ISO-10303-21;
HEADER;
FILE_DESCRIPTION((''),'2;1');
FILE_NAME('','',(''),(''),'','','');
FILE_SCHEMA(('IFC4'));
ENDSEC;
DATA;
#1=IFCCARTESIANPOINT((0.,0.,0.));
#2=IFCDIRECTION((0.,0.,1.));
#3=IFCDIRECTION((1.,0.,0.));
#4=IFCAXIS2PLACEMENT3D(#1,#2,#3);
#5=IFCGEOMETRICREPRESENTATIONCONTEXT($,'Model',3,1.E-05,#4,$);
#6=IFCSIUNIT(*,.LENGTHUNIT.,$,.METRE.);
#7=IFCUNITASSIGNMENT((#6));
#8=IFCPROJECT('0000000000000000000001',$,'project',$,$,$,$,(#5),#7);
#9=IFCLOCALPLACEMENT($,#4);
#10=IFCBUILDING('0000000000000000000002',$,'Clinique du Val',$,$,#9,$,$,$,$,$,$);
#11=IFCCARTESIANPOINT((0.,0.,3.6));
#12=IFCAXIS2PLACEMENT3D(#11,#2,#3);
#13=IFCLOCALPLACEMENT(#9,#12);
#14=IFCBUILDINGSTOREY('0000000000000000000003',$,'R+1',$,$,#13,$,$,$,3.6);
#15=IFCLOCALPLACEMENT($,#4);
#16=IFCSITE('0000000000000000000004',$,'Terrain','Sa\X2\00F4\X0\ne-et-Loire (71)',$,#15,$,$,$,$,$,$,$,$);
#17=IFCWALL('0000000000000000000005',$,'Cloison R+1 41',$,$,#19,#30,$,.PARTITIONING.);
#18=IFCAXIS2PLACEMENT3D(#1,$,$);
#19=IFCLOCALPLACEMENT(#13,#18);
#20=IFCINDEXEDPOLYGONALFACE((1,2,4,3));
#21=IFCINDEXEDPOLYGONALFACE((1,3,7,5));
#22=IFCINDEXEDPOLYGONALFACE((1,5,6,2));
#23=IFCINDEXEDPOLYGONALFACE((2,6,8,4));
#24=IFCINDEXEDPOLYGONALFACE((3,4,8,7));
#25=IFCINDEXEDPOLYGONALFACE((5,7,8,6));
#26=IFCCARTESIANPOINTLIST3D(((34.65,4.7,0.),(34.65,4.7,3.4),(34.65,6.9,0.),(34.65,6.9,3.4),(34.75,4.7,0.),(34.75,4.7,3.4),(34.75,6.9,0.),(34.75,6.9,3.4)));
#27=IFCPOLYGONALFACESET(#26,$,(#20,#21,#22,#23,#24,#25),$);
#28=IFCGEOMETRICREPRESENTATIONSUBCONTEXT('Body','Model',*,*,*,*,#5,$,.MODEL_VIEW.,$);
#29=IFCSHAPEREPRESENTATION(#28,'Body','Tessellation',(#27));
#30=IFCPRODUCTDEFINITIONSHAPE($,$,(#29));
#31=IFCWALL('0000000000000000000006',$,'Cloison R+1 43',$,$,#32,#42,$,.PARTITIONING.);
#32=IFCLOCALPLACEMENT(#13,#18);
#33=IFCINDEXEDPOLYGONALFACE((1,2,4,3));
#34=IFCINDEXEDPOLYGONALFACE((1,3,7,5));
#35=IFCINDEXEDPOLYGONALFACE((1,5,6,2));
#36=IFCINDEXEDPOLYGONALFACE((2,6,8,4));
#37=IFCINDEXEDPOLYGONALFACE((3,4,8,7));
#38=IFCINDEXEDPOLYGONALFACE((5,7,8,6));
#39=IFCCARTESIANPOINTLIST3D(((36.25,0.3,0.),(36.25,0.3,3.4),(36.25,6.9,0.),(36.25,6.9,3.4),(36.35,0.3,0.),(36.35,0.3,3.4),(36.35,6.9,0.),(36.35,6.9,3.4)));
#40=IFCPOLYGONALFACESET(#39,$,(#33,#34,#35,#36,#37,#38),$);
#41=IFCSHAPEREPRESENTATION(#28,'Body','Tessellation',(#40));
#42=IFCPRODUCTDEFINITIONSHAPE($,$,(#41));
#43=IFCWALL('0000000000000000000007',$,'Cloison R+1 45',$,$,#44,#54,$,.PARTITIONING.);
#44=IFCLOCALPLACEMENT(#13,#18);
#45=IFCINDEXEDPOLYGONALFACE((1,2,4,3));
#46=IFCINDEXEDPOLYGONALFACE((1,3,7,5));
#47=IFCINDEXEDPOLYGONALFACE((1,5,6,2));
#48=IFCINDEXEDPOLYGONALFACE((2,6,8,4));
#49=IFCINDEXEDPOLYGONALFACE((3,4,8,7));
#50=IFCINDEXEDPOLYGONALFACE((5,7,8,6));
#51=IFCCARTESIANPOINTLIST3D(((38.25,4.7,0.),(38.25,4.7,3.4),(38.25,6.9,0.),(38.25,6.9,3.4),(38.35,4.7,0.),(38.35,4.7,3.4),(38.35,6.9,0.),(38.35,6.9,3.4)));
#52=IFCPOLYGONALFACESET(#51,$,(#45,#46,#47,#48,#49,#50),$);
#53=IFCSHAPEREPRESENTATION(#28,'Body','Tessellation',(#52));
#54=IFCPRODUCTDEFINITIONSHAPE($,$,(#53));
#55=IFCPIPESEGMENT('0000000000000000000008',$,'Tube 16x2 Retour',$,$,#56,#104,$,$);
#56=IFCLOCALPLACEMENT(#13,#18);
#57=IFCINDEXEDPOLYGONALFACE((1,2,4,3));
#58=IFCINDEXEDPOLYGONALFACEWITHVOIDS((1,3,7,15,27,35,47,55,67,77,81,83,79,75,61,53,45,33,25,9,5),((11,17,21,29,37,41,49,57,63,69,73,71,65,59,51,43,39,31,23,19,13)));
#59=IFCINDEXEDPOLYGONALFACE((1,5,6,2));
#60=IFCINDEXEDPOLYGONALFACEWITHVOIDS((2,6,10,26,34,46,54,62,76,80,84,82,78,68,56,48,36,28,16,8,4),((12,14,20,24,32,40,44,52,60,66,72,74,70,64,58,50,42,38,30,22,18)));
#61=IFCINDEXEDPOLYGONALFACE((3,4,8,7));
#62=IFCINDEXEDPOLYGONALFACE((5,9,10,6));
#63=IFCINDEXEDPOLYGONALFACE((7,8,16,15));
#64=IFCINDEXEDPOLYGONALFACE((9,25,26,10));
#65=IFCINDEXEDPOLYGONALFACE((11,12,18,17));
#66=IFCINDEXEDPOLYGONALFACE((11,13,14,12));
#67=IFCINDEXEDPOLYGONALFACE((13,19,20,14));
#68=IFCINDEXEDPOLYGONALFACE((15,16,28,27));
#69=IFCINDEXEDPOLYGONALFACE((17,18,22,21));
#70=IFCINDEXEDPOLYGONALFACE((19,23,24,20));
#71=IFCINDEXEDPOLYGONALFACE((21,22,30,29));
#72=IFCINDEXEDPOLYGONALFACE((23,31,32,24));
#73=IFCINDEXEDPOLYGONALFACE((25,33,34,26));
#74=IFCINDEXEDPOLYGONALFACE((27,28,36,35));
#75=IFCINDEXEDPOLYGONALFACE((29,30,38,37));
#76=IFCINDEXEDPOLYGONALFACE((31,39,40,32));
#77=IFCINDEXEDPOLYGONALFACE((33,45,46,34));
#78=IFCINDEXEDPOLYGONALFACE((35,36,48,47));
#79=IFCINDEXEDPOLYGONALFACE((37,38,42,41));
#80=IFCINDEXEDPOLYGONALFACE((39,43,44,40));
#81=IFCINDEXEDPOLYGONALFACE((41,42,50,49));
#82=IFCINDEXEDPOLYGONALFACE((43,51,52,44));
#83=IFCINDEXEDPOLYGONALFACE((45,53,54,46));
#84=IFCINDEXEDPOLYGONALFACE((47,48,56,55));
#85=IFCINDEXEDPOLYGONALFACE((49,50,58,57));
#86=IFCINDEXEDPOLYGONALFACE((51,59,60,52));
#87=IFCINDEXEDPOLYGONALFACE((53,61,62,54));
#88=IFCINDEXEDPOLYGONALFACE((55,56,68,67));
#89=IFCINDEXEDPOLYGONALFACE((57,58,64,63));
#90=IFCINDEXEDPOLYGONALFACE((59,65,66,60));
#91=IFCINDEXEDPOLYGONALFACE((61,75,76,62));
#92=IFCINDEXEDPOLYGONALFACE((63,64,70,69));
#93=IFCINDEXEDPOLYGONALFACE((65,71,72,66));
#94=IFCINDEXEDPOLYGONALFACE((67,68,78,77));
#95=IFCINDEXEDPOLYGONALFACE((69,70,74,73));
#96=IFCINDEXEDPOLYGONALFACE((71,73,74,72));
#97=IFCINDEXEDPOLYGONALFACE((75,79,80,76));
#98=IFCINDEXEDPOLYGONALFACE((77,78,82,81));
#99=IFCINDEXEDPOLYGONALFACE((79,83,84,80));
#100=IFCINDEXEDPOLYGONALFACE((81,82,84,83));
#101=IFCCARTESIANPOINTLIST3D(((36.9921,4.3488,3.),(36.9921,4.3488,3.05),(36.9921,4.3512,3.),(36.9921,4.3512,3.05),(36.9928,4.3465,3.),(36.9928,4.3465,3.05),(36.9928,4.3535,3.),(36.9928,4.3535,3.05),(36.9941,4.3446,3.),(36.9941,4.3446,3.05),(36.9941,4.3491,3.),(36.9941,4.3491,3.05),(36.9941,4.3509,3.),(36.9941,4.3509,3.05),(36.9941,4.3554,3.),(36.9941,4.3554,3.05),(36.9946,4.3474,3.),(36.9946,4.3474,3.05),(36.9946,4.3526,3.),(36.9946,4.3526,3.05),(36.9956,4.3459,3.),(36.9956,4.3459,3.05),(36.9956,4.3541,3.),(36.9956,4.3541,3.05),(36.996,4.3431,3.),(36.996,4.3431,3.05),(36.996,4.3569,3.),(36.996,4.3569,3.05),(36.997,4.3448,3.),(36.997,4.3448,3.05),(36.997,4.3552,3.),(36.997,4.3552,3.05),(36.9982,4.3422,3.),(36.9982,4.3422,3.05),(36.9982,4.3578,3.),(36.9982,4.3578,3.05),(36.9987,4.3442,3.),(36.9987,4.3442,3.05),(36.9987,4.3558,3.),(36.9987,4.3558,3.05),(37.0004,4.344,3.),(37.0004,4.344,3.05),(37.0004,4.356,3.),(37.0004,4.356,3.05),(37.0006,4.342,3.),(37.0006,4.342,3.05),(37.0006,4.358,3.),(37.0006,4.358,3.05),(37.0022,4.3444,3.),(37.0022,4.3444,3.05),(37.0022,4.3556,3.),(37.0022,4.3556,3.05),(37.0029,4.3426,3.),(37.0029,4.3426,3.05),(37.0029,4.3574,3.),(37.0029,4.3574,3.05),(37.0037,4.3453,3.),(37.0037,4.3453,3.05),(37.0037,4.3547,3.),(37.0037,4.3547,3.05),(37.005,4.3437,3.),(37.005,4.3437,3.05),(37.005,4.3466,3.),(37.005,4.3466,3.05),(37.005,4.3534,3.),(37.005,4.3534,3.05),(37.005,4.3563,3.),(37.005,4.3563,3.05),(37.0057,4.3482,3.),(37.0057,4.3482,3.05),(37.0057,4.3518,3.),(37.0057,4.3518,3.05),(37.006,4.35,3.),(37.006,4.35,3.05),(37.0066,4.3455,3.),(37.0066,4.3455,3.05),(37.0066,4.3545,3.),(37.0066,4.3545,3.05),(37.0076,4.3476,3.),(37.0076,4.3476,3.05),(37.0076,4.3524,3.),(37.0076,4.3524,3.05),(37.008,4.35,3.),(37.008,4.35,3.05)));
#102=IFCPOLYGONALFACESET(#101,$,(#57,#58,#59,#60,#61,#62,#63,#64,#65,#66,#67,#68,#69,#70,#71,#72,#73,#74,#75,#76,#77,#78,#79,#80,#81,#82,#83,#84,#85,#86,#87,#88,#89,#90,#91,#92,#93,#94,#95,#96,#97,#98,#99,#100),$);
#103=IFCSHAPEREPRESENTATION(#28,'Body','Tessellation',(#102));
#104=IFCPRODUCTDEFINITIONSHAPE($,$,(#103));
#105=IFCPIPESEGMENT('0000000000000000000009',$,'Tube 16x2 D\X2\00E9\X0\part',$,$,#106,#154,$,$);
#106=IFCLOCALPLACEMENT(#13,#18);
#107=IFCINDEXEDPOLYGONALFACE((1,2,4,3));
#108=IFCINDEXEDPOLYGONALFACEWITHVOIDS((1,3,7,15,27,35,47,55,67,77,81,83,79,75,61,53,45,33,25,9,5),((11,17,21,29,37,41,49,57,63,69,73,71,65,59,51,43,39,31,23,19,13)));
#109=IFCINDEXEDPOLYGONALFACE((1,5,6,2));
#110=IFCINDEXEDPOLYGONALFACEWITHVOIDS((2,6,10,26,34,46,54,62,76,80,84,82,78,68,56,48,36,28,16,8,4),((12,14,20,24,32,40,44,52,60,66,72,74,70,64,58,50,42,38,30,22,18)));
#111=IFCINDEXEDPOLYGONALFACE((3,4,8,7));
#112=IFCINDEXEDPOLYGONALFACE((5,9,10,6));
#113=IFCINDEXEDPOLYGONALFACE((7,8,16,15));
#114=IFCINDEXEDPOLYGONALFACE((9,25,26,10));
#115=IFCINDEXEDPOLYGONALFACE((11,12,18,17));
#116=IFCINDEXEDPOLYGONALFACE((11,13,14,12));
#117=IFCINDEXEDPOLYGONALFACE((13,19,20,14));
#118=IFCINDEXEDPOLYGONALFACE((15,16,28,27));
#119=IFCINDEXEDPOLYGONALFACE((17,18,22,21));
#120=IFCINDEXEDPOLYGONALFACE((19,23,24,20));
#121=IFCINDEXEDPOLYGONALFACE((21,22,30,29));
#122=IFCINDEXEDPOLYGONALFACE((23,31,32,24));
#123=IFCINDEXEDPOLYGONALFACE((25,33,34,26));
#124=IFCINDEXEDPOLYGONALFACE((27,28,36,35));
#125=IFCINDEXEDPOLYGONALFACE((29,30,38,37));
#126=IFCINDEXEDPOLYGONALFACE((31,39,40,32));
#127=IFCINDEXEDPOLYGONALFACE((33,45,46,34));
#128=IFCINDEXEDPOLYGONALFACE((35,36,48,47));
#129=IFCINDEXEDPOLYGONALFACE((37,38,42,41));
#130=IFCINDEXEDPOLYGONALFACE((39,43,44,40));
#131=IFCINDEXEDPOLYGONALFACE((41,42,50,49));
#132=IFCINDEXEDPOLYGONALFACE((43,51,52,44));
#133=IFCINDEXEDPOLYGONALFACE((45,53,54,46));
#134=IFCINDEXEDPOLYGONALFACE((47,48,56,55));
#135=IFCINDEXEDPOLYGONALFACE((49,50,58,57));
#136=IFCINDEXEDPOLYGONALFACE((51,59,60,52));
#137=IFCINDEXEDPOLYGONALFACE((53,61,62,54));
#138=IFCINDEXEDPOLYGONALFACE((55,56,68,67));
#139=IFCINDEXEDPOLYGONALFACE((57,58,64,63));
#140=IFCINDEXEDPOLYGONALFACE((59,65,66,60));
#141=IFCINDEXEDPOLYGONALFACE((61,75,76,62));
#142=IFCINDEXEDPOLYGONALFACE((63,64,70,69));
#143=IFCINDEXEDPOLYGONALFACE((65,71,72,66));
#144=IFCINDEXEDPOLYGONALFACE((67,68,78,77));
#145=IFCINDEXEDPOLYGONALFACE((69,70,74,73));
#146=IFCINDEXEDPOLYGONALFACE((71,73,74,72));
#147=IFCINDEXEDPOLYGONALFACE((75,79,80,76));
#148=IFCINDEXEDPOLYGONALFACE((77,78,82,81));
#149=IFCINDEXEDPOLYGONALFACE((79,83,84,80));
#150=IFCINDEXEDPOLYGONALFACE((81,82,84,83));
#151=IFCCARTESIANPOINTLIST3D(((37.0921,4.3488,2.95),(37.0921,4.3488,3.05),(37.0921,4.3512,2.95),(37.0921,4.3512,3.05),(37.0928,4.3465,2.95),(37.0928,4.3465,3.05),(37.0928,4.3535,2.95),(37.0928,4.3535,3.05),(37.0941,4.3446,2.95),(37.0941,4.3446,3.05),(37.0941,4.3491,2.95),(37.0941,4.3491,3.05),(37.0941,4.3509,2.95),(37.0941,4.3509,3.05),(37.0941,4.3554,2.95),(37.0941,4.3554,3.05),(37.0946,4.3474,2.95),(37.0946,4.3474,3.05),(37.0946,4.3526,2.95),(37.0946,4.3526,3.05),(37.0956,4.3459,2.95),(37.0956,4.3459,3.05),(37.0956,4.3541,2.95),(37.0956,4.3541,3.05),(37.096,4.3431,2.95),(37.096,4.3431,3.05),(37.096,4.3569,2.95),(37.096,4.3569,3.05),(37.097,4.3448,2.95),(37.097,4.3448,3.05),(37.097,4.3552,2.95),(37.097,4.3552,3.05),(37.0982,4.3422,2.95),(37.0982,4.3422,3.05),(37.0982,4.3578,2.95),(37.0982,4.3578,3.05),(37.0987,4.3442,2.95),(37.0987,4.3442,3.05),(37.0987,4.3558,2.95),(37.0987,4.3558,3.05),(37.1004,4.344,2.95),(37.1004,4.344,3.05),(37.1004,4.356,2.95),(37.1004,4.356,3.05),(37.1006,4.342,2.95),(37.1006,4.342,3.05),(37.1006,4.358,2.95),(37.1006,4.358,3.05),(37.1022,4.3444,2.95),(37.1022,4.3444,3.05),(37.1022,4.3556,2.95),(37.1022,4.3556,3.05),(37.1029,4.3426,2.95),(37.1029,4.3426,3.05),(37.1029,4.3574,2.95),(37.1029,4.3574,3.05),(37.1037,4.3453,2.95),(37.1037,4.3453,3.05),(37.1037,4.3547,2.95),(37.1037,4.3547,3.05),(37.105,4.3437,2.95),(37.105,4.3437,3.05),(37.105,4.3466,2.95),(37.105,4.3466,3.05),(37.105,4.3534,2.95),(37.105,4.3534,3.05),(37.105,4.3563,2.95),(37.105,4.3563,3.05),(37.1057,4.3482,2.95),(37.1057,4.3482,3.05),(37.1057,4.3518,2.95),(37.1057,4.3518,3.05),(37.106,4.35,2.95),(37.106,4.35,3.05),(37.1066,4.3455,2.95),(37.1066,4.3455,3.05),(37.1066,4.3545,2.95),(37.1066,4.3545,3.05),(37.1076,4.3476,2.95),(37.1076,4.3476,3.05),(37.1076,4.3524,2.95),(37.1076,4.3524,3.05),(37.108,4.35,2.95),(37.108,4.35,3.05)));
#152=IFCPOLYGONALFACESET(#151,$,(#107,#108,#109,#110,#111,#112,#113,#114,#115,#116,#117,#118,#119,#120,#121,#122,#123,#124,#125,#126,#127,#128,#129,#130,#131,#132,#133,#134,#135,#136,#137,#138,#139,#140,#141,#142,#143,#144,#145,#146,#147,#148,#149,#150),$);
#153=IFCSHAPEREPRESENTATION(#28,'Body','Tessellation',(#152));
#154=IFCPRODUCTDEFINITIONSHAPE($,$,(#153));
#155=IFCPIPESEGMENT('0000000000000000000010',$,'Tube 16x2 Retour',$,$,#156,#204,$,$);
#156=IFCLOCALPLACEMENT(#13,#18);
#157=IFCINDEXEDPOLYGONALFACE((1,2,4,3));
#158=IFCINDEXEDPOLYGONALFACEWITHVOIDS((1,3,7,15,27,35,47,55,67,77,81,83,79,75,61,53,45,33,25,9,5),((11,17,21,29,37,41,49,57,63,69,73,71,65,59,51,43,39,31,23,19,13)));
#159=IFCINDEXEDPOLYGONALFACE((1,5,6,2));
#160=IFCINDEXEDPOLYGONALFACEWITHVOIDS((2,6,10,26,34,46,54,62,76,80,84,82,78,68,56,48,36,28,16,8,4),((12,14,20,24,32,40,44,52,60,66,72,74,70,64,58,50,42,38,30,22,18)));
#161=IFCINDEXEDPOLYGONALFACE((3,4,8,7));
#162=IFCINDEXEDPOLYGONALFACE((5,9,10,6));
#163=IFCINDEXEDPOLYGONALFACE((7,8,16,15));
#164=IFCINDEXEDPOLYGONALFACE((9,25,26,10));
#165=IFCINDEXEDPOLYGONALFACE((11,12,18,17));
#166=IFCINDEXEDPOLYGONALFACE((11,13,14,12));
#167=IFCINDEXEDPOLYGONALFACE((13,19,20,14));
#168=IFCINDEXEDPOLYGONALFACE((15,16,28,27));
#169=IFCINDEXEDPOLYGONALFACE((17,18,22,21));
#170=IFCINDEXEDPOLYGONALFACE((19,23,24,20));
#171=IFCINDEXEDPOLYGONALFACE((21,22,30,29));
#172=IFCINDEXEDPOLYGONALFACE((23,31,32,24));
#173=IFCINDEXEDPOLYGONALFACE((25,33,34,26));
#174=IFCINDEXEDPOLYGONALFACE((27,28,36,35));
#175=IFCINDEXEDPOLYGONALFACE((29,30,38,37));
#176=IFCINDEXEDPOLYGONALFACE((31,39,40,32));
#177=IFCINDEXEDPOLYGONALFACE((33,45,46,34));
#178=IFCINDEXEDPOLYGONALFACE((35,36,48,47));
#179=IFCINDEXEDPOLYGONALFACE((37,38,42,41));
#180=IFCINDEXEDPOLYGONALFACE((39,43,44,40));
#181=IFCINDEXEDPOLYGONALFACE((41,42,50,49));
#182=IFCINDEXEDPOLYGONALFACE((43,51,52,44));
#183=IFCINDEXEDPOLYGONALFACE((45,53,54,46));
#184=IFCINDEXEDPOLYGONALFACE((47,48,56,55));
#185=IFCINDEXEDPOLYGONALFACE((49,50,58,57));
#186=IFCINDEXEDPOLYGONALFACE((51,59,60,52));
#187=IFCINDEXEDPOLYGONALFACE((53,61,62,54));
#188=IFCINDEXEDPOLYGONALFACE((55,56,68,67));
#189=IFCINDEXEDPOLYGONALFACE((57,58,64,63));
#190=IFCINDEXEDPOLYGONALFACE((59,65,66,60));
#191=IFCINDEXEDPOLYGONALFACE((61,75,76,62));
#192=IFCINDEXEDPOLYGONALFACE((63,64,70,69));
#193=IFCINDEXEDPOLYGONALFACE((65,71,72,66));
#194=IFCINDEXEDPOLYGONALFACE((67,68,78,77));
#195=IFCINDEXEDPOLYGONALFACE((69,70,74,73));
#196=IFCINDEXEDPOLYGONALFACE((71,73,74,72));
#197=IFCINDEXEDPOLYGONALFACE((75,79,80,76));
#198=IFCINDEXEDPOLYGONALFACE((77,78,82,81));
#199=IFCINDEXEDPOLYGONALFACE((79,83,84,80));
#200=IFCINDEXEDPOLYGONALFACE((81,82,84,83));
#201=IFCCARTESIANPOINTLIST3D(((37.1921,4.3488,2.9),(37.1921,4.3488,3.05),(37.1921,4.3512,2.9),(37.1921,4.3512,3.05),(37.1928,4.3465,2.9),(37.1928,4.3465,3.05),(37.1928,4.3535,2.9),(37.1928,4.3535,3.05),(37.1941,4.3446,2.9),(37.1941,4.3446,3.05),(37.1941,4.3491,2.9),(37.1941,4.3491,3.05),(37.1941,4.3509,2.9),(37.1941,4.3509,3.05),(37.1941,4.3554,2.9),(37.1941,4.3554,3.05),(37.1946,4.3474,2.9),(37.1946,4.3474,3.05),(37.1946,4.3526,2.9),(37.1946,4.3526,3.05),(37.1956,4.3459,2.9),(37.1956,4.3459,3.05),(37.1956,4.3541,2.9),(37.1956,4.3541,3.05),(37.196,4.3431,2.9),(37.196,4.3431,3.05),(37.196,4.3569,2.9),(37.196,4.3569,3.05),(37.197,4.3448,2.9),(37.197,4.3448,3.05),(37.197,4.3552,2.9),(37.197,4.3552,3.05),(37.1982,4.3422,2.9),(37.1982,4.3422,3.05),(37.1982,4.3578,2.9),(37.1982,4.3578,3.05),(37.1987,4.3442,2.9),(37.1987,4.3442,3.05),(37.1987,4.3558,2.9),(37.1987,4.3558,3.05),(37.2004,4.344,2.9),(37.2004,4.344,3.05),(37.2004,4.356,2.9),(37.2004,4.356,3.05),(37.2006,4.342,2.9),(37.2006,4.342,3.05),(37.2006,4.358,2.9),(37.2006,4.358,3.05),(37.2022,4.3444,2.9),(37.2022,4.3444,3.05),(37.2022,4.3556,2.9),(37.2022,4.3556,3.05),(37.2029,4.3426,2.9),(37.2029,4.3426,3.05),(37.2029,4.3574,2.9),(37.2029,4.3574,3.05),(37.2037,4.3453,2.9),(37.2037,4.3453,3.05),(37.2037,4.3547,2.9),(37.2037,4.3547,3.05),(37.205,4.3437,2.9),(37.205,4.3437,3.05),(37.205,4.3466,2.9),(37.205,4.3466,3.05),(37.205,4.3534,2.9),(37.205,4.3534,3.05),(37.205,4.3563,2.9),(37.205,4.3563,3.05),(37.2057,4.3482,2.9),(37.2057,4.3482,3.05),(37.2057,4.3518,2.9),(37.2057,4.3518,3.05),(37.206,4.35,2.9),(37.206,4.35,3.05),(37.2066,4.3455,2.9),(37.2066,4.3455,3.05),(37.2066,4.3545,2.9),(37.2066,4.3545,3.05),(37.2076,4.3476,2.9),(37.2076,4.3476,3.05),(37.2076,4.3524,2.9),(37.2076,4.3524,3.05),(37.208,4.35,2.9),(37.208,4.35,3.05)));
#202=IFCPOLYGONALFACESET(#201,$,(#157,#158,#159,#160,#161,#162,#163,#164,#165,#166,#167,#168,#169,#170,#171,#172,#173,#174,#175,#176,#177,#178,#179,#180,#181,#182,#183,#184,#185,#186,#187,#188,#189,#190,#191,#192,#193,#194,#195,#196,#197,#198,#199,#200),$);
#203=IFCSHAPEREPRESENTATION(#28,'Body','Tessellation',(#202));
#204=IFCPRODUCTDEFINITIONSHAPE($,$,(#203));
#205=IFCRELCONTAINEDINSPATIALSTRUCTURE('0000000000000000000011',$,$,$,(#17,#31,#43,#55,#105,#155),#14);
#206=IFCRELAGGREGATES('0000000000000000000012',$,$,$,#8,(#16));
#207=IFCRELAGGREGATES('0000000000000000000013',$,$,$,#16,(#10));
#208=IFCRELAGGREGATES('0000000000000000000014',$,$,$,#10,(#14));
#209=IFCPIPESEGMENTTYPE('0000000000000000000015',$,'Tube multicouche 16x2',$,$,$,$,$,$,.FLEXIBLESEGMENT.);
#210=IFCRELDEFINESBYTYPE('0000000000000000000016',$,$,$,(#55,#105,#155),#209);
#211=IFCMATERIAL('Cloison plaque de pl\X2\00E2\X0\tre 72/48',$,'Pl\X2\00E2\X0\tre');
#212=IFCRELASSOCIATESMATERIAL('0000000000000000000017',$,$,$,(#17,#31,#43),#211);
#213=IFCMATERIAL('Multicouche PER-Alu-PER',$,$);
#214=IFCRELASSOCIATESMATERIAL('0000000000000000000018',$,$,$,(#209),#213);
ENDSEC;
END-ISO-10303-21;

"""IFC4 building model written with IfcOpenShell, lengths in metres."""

from ifc_helpers import new_model, si_unit, frame, frame_2d, origin_with_axes, place, context, subcontext, project, spatial, rectangle, hollow_circle, extrude, material, type_object, element, save


model = new_model("IFC4")

# Units and contexts
model_context = context("Model", 3, precision=1e-05, world=origin_with_axes())
body_context = subcontext(model_context, "Body", "Model", "MODEL_VIEW")
ifc_project = project(units=[si_unit("LENGTHUNIT", "METRE")], contexts=[model_context])

# Site, building, storey
site_placement = place(None, origin_with_axes())
site = spatial("IfcSite", under=ifc_project, at=site_placement, Name="Terrain", Description="Saône-et-Loire (71)")
building_placement = place(None, origin_with_axes())
building = spatial("IfcBuilding", under=site, at=building_placement, Name="Clinique du Val")
storey_placement = place(building_placement, frame((0.0, 0.0, 3.6), z_axis=(0.0, 0.0, 1.0), x_axis=(1.0, 0.0, 0.0)))
storey = spatial("IfcBuildingStorey", under=building, at=storey_placement, Name="R+1", Elevation=3.6)

# Walls
ifc_material_1 = material(Name="Cloison plaque de plâtre 72/48", Category="Plâtre")
wall_1_placement = place(storey_placement, frame((34.65, 4.7, 0.0), z_axis=(0.0, 0.0, 1.0), x_axis=(1.0, 0.0, 0.0)))
element("IfcWall", 1, at=wall_1_placement, inside=storey, material=ifc_material_1, Name="Cloison R+1 41", PredefinedType="PARTITIONING", context=body_context, shape_type="SweptSolid", body=[
    extrude(rectangle(XDim=0.1, YDim=2.2, at=frame_2d((0.05, 1.1))), origin_with_axes(), (0.0, 0.0, 1.0), 3.4),
])
wall_2_placement = place(storey_placement, frame((36.25, 0.3, 0.0), z_axis=(0.0, 0.0, 1.0), x_axis=(1.0, 0.0, 0.0)))
element("IfcWall", 2, at=wall_2_placement, inside=storey, material=ifc_material_1, Name="Cloison R+1 43", PredefinedType="PARTITIONING", context=body_context, shape_type="SweptSolid", body=[
    extrude(rectangle(XDim=0.1, YDim=6.6, at=frame_2d((0.05, 3.3))), origin_with_axes(), (0.0, 0.0, 1.0), 3.4),
])
wall_3_placement = place(storey_placement, frame((38.25, 4.7, 0.0), z_axis=(0.0, 0.0, 1.0), x_axis=(1.0, 0.0, 0.0)))
element("IfcWall", 3, at=wall_3_placement, inside=storey, material=ifc_material_1, Name="Cloison R+1 45", PredefinedType="PARTITIONING", context=body_context, shape_type="SweptSolid", body=[
    extrude(rectangle(XDim=0.1, YDim=2.2, at=frame_2d((0.05, 1.1))), origin_with_axes(), (0.0, 0.0, 1.0), 3.4),
])

# Pipe segments
ifc_material_2 = material(Name="Multicouche PER-Alu-PER")
pipe_segment_type = type_object("IfcPipeSegmentType", Name="Tube multicouche 16x2", PredefinedType="FLEXIBLESEGMENT", material=ifc_material_2)
pipe_segment_1_placement = place(storey_placement, frame((37.0, 4.35, 3.0), z_axis=(0.0, 0.0, 1.0), x_axis=(1.0, 0.0, 0.0)))
element("IfcPipeSegment", 4, at=pipe_segment_1_placement, inside=storey, type_object=pipe_segment_type, Name="Tube 16x2 Retour", context=body_context, shape_type="SweptSolid", body=[
    extrude(hollow_circle(Radius=0.008, WallThickness=0.002), origin_with_axes(), (0.0, 0.0, 1.0), 0.05),
])
pipe_segment_2_placement = place(storey_placement, frame((37.1, 4.35, 2.95), z_axis=(0.0, 0.0, 1.0), x_axis=(1.0, 0.0, 0.0)))
element("IfcPipeSegment", 5, at=pipe_segment_2_placement, inside=storey, type_object=pipe_segment_type, Name="Tube 16x2 Départ", context=body_context, shape_type="SweptSolid", body=[
    extrude(hollow_circle(Radius=0.008, WallThickness=0.002), origin_with_axes(), (0.0, 0.0, 1.0), 0.1),
])
pipe_segment_3_placement = place(storey_placement, frame((37.2, 4.35, 2.9), z_axis=(0.0, 0.0, 1.0), x_axis=(1.0, 0.0, 0.0)))
element("IfcPipeSegment", 6, at=pipe_segment_3_placement, inside=storey, type_object=pipe_segment_type, Name="Tube 16x2 Retour", context=body_context, shape_type="SweptSolid", body=[
    extrude(hollow_circle(Radius=0.008, WallThickness=0.002), origin_with_axes(), (0.0, 0.0, 1.0), 0.15),
])

save(model, "model.ifc")
